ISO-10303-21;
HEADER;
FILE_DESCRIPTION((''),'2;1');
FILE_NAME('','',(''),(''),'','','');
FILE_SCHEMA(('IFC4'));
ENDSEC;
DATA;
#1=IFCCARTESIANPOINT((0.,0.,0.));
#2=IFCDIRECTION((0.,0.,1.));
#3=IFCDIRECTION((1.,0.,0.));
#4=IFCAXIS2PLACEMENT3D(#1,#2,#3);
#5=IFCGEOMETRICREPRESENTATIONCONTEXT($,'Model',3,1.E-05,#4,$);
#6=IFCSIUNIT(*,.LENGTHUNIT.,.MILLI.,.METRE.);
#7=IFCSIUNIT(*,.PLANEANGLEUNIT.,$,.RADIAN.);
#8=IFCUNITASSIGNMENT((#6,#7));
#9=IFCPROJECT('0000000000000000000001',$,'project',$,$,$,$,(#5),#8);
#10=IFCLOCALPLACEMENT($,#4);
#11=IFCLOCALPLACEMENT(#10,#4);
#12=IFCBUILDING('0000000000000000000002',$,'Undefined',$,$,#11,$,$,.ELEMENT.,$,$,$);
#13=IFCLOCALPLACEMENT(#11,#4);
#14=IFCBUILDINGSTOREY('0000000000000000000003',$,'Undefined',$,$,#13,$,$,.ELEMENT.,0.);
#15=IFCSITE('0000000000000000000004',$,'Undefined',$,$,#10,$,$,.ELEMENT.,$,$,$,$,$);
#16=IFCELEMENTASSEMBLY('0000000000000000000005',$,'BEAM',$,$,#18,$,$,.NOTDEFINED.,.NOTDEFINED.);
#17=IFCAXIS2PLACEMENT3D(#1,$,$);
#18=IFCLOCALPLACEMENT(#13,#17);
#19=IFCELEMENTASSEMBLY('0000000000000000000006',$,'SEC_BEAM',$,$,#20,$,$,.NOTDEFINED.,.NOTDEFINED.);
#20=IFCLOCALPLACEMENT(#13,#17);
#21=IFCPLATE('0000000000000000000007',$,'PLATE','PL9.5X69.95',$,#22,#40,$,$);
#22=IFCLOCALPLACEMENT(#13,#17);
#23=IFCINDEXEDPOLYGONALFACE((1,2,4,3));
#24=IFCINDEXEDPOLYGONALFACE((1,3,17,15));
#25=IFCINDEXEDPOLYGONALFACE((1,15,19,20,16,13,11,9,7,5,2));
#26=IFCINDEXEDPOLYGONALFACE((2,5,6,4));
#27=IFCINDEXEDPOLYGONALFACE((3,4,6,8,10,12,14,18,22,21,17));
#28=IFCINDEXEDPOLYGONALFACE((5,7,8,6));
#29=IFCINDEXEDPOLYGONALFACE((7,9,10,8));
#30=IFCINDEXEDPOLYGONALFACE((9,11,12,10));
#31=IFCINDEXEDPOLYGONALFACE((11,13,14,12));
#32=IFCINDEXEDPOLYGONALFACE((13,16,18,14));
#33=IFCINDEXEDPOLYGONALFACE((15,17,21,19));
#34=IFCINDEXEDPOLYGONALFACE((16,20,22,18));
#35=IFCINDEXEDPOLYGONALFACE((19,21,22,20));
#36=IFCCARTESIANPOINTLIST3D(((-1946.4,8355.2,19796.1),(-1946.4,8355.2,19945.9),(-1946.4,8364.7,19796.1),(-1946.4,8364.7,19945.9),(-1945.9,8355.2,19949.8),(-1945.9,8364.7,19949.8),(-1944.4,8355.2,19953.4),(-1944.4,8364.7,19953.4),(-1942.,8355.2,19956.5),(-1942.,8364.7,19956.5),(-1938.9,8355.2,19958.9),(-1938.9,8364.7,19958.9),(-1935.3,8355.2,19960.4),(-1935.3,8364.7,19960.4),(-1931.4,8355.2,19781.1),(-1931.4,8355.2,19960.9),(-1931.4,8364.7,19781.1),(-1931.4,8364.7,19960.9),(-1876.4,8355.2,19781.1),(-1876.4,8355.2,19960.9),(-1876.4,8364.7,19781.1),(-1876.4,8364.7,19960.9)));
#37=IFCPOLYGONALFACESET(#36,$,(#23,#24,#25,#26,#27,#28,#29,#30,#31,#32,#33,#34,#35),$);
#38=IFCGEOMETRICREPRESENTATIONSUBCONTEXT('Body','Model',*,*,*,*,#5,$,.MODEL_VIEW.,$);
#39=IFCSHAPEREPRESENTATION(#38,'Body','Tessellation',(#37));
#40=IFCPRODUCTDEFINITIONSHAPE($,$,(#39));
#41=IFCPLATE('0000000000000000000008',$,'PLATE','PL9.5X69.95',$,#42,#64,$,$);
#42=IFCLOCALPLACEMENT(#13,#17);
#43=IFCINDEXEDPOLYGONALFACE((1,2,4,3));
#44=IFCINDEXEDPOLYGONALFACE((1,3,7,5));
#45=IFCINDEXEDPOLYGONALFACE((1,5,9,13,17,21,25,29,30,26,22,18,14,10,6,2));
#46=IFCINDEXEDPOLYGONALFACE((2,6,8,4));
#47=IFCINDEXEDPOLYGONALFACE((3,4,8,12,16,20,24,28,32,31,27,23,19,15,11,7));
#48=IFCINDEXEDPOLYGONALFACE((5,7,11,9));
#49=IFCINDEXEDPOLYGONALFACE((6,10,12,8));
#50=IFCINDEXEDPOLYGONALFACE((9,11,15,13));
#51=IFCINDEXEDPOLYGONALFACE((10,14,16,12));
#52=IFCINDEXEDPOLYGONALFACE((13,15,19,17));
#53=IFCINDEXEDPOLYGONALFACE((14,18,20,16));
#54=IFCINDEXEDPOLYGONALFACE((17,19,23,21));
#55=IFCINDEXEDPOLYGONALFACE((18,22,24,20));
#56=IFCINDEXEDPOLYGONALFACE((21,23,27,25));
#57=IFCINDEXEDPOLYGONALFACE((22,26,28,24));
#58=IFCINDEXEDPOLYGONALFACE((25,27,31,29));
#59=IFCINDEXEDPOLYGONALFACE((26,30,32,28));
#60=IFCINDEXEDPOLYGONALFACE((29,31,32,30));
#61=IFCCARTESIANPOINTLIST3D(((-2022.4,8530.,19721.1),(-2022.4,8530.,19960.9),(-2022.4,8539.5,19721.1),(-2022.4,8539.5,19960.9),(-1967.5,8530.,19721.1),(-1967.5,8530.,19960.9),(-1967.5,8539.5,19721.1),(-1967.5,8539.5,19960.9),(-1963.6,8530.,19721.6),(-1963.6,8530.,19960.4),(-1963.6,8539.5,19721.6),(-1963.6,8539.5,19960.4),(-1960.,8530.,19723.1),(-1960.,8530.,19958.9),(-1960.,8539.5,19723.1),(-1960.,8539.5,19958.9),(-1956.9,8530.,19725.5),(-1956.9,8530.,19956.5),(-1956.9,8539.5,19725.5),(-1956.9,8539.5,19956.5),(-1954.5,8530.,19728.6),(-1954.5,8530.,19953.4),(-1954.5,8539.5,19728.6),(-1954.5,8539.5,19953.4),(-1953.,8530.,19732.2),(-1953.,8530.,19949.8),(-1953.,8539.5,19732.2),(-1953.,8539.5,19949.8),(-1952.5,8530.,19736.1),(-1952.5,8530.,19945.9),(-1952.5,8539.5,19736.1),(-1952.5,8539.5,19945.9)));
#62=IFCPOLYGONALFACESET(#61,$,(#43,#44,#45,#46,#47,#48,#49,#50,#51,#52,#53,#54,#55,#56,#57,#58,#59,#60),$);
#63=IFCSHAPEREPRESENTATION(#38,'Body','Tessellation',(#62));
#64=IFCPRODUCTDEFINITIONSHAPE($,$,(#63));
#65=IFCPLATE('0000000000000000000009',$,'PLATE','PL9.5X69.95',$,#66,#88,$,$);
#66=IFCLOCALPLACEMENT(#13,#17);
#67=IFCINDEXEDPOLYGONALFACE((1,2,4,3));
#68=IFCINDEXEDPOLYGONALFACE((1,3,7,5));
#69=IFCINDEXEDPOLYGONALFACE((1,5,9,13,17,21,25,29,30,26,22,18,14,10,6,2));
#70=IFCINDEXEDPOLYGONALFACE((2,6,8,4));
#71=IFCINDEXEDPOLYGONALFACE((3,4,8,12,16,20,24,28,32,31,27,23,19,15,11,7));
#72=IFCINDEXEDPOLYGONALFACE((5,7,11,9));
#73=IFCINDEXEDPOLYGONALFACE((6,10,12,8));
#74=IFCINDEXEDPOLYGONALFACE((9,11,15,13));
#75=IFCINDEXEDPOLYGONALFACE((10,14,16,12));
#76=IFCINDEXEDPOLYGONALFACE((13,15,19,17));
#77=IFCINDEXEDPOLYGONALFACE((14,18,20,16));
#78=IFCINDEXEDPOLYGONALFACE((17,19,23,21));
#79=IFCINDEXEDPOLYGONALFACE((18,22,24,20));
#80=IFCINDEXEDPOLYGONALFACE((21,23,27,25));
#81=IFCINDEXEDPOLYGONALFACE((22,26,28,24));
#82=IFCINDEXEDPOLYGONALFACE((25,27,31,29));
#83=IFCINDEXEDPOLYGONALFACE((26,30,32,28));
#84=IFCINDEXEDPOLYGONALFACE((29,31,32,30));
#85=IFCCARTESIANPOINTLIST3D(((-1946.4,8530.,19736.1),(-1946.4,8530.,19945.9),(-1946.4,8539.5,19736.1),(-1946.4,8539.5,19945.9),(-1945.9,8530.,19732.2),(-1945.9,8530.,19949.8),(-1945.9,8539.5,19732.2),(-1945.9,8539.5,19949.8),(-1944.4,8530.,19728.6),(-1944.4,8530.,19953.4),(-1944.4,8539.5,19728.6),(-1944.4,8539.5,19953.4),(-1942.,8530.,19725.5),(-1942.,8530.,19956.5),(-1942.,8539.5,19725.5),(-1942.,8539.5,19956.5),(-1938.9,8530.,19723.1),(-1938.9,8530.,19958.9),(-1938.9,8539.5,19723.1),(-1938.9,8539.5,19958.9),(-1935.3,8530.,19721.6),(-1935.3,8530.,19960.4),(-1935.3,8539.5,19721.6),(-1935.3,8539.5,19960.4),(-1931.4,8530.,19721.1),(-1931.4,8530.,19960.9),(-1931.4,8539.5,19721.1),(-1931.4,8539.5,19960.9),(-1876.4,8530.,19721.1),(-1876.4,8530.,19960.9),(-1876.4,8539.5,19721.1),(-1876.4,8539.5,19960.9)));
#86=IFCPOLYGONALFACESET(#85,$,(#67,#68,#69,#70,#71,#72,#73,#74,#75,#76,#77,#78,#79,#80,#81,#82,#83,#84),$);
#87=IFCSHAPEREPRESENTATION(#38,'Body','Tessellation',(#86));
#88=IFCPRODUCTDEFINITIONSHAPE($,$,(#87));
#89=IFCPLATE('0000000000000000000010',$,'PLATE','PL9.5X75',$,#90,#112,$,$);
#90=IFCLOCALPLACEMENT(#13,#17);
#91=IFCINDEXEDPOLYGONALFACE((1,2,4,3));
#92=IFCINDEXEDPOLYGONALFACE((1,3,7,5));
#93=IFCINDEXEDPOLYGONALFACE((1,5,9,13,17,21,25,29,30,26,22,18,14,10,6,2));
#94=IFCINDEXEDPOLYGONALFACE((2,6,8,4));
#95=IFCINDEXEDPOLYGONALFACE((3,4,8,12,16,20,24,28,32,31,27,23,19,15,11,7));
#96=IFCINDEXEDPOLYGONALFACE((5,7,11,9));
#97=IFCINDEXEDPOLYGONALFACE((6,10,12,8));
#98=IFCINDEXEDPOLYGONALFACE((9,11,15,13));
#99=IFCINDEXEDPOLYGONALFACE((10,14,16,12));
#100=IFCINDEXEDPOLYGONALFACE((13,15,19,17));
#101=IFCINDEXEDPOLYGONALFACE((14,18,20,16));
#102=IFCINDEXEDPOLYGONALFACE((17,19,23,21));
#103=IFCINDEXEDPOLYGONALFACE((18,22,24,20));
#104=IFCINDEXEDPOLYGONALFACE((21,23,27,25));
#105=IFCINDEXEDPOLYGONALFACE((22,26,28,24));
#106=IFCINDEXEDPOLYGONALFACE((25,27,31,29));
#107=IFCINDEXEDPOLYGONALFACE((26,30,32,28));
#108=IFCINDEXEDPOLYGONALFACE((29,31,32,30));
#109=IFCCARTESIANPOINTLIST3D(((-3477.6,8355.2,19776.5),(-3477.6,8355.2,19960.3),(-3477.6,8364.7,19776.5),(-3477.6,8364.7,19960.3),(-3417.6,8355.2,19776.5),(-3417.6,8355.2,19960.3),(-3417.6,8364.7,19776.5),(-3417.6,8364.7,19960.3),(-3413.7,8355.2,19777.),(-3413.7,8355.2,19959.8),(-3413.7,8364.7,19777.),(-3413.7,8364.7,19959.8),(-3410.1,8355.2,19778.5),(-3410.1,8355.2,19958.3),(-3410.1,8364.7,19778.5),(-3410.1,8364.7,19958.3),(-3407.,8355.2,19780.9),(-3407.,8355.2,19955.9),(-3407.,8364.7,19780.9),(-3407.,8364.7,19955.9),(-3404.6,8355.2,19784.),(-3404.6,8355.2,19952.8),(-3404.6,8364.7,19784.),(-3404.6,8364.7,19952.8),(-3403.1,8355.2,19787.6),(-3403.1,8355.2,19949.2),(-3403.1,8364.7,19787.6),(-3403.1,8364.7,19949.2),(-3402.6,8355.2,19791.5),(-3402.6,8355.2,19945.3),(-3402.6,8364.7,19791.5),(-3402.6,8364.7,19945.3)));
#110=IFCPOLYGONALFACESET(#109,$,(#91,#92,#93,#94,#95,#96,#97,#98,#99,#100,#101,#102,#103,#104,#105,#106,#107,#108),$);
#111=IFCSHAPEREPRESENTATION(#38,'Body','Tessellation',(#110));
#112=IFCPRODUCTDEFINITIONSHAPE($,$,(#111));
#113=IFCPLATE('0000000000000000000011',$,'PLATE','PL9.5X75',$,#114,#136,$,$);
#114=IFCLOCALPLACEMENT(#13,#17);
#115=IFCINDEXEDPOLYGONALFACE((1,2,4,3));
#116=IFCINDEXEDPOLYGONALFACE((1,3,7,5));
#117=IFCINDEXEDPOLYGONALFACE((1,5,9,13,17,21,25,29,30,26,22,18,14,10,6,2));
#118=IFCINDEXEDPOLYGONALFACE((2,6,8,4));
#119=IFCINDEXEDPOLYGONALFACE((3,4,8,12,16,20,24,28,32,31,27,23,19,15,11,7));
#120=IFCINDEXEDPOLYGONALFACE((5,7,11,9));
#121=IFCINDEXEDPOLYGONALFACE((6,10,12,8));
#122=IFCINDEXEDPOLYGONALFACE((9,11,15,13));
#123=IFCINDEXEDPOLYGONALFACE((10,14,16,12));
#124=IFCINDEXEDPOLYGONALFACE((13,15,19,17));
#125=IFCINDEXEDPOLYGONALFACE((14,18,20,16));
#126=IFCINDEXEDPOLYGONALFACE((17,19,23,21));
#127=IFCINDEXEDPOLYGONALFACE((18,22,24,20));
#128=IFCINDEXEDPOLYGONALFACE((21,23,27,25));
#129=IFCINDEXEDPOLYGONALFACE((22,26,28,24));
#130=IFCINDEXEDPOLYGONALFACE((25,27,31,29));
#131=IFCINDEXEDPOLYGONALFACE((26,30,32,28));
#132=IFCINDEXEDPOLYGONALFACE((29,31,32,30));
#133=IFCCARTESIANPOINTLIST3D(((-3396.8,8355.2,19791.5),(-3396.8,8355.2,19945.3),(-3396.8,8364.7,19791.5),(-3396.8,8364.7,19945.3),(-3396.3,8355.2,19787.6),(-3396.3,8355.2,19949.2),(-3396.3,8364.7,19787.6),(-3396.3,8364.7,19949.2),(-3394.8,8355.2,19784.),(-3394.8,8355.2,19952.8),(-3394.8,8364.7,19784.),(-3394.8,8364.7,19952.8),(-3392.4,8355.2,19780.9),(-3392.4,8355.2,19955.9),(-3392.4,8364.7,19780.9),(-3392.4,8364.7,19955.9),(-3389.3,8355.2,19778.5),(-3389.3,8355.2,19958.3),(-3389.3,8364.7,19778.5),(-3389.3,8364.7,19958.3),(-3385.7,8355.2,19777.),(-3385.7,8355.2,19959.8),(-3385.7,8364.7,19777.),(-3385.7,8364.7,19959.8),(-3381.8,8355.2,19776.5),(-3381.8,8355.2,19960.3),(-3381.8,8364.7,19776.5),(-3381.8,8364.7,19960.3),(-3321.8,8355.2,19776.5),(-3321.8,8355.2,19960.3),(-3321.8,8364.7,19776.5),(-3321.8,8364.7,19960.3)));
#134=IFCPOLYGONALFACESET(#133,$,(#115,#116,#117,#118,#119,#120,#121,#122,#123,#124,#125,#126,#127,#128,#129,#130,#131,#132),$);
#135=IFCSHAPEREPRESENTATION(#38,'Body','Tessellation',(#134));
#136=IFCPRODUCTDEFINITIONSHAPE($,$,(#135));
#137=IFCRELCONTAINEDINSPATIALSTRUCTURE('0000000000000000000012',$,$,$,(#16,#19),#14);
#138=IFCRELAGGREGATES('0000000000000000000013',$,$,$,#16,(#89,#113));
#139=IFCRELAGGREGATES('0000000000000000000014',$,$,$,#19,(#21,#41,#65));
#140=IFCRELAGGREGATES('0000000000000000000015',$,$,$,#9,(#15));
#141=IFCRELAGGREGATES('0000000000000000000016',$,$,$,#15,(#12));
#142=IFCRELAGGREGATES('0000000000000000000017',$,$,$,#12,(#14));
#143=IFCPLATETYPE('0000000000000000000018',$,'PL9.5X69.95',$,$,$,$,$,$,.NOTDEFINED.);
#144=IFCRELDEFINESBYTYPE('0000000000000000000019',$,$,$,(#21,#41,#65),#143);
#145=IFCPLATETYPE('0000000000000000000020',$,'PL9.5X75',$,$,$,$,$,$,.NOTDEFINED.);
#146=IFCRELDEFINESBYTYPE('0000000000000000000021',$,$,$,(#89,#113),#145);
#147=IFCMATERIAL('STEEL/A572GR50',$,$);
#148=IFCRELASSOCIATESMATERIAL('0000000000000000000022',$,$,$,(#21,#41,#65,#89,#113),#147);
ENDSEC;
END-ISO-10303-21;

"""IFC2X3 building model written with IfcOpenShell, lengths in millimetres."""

from ifc_helpers import new_model, si_unit, frame, frame_2d, origin_with_axes, place, context, subcontext, project, spatial, polyline, circle_curve, parameter, trimmed, segment, composite_curve, outline, extrude, material, type_object, element, aggregate, save


model = new_model("IFC2X3")

# Units and contexts
model_context = context("Model", 3, precision=1e-05, world=origin_with_axes())
body_context = subcontext(model_context, "Body", "Model", "MODEL_VIEW")
ifc_project = project(units=[si_unit("LENGTHUNIT", "METRE", prefix="MILLI"), si_unit("PLANEANGLEUNIT", "RADIAN")], contexts=[model_context])

# Site, building, storey
site_placement = place(None, origin_with_axes())
site = spatial("IfcSite", under=ifc_project, at=site_placement, Name="Undefined", CompositionType="ELEMENT")
building_placement = place(site_placement, origin_with_axes())
building = spatial("IfcBuilding", under=site, at=building_placement, Name="Undefined", CompositionType="ELEMENT")
storey_placement = place(building_placement, origin_with_axes())
storey = spatial("IfcBuildingStorey", under=building, at=storey_placement, Name="Undefined", CompositionType="ELEMENT", Elevation=0.0)

# Element assemblies
assembly_1_placement = place(storey_placement, origin_with_axes())
assembly_1 = element("IfcElementAssembly", 1, at=assembly_1_placement, inside=storey, Name="BEAM", AssemblyPlace="NOTDEFINED", PredefinedType="NOTDEFINED")
ifc_material_1 = material(Name="STEEL/A572GR50")
assembly_2_placement = place(storey_placement, origin_with_axes())
assembly_2 = element("IfcElementAssembly", 2, at=assembly_2_placement, inside=storey, Name="SEC_BEAM", AssemblyPlace="NOTDEFINED", PredefinedType="NOTDEFINED")

# Plates
plate_type_1 = type_object("IfcPlateType", Name="PL9.5X69.95", PredefinedType="NOTDEFINED")
plate_1_placement = place(assembly_2_placement, frame((-1946.4, 8360.0, 19781.1), z_axis=(0.0, -1.0, 0.0), x_axis=(1.0, 0.0, 0.0)))
plate_1 = element("IfcPlate", 3, at=plate_1_placement, type_object=plate_type_1, material=ifc_material_1, Name="PLATE", Description="PL9.5X69.95", context=body_context, shape_type="SweptSolid", body=[
    extrude(outline(composite_curve([segment(polyline([(0.0, 15.0), (15.0, 0.0), (69.9, 0.0), (69.9, 179.8), (15.0, 179.8)]), True, "CONTINUOUS"), segment(trimmed(circle_curve(frame_2d((15.0, 164.8), x_axis=(0.0, 1.0)), 15.0), [parameter(0.0)], [parameter(1.570796)], True, "PARAMETER"), True, "CONTINUOUS"), segment(polyline([(0.0, 164.8), (0.0, 15.0)]), True, "CONTINUOUS")], self_intersect=True)), frame((0.0, 0.0, -4.8), z_axis=(0.0, 0.0, 1.0), x_axis=(1.0, 0.0, 0.0)), (0.0, 0.0, 1.0), 9.5),
])
plate_2_placement = place(assembly_2_placement, frame((-2022.4, 8534.8, 19721.1), z_axis=(0.0, -1.0, 0.0), x_axis=(1.0, 0.0, 0.0)))
plate_2 = element("IfcPlate", 4, at=plate_2_placement, type_object=plate_type_1, material=ifc_material_1, Name="PLATE", Description="PL9.5X69.95", context=body_context, shape_type="SweptSolid", body=[
    extrude(outline(composite_curve([segment(polyline([(0.0, 0.0), (54.9, 0.0)]), True, "CONTINUOUS"), segment(trimmed(circle_curve(frame_2d((54.9, 15.0), x_axis=(0.0, -1.0)), 15.0), [parameter(0.0)], [parameter(1.570796)], True, "PARAMETER"), True, "CONTINUOUS"), segment(polyline([(69.9, 15.0), (69.9, 224.8)]), True, "CONTINUOUS"), segment(trimmed(circle_curve(frame_2d((54.9, 224.8), x_axis=(1.0, 0.0)), 15.0), [parameter(0.0)], [parameter(1.570796)], True, "PARAMETER"), True, "CONTINUOUS"), segment(polyline([(54.9, 239.8), (0.0, 239.8), (0.0, 0.0)]), True, "CONTINUOUS")], self_intersect=True)), frame((0.0, 0.0, -4.8), z_axis=(0.0, 0.0, 1.0), x_axis=(1.0, 0.0, 0.0)), (0.0, 0.0, 1.0), 9.5),
])
plate_3_placement = place(assembly_2_placement, frame((-1946.4, 8534.8, 19721.1), z_axis=(0.0, -1.0, 0.0), x_axis=(1.0, 0.0, 0.0)))
plate_3 = element("IfcPlate", 5, at=plate_3_placement, type_object=plate_type_1, material=ifc_material_1, Name="PLATE", Description="PL9.5X69.95", context=body_context, shape_type="SweptSolid", body=[
    extrude(outline(composite_curve([segment(trimmed(circle_curve(frame_2d((15.0, 15.0), x_axis=(-1.0, 0.0)), 15.0), [parameter(0.0)], [parameter(1.570796)], True, "PARAMETER"), True, "CONTINUOUS"), segment(polyline([(15.0, 0.0), (69.9, 0.0), (69.9, 239.8), (15.0, 239.8)]), True, "CONTINUOUS"), segment(trimmed(circle_curve(frame_2d((15.0, 224.8), x_axis=(0.0, 1.0)), 15.0), [parameter(0.0)], [parameter(1.570796)], True, "PARAMETER"), True, "CONTINUOUS"), segment(polyline([(0.0, 224.8), (0.0, 15.0)]), True, "CONTINUOUS")], self_intersect=True)), frame((0.0, 0.0, -4.8), z_axis=(0.0, 0.0, 1.0), x_axis=(1.0, 0.0, 0.0)), (0.0, 0.0, 1.0), 9.5),
])
plate_type_2 = type_object("IfcPlateType", Name="PL9.5X75", PredefinedType="NOTDEFINED")
plate_4_placement = place(assembly_1_placement, frame((-3477.6, 8360.0, 19776.5), z_axis=(0.0, -1.0, 0.0), x_axis=(1.0, 0.0, 0.0)))
plate_4 = element("IfcPlate", 6, at=plate_4_placement, type_object=plate_type_2, material=ifc_material_1, Name="PLATE", Description="PL9.5X75", context=body_context, shape_type="SweptSolid", body=[
    extrude(outline(composite_curve([segment(polyline([(0.0, 0.0), (60.0, 0.0)]), True, "CONTINUOUS"), segment(trimmed(circle_curve(frame_2d((60.0, 15.0), x_axis=(0.0, -1.0)), 15.0), [parameter(0.0)], [parameter(1.570796)], True, "PARAMETER"), True, "CONTINUOUS"), segment(polyline([(75.0, 15.0), (75.0, 168.8)]), True, "CONTINUOUS"), segment(trimmed(circle_curve(frame_2d((60.0, 168.8), x_axis=(1.0, 0.0)), 15.0), [parameter(0.0)], [parameter(1.570796)], True, "PARAMETER"), True, "CONTINUOUS"), segment(polyline([(60.0, 183.8), (0.0, 183.8), (0.0, 0.0)]), True, "CONTINUOUS")], self_intersect=True)), frame((0.0, 0.0, -4.8), z_axis=(0.0, 0.0, 1.0), x_axis=(1.0, 0.0, 0.0)), (0.0, 0.0, 1.0), 9.5),
])
plate_5_placement = place(assembly_1_placement, frame((-3396.8, 8360.0, 19776.5), z_axis=(0.0, -1.0, 0.0), x_axis=(1.0, 0.0, 0.0)))
plate_5 = element("IfcPlate", 7, at=plate_5_placement, type_object=plate_type_2, material=ifc_material_1, Name="PLATE", Description="PL9.5X75", context=body_context, shape_type="SweptSolid", body=[
    extrude(outline(composite_curve([segment(trimmed(circle_curve(frame_2d((15.0, 15.0), x_axis=(-1.0, 0.0)), 15.0), [parameter(0.0)], [parameter(1.570796)], True, "PARAMETER"), True, "CONTINUOUS"), segment(polyline([(15.0, 0.0), (75.0, 0.0), (75.0, 183.8), (15.0, 183.8)]), True, "CONTINUOUS"), segment(trimmed(circle_curve(frame_2d((15.0, 168.8), x_axis=(0.0, 1.0)), 15.0), [parameter(0.0)], [parameter(1.570796)], True, "PARAMETER"), True, "CONTINUOUS"), segment(polyline([(0.0, 168.8), (0.0, 15.0)]), True, "CONTINUOUS")], self_intersect=True)), frame((0.0, 0.0, -4.8), z_axis=(0.0, 0.0, 1.0), x_axis=(1.0, 0.0, 0.0)), (0.0, 0.0, 1.0), 9.5),
])

aggregate(assembly_1, [plate_4, plate_5])

aggregate(assembly_2, [plate_1, plate_2, plate_3])

save(model, "model.ifc")
